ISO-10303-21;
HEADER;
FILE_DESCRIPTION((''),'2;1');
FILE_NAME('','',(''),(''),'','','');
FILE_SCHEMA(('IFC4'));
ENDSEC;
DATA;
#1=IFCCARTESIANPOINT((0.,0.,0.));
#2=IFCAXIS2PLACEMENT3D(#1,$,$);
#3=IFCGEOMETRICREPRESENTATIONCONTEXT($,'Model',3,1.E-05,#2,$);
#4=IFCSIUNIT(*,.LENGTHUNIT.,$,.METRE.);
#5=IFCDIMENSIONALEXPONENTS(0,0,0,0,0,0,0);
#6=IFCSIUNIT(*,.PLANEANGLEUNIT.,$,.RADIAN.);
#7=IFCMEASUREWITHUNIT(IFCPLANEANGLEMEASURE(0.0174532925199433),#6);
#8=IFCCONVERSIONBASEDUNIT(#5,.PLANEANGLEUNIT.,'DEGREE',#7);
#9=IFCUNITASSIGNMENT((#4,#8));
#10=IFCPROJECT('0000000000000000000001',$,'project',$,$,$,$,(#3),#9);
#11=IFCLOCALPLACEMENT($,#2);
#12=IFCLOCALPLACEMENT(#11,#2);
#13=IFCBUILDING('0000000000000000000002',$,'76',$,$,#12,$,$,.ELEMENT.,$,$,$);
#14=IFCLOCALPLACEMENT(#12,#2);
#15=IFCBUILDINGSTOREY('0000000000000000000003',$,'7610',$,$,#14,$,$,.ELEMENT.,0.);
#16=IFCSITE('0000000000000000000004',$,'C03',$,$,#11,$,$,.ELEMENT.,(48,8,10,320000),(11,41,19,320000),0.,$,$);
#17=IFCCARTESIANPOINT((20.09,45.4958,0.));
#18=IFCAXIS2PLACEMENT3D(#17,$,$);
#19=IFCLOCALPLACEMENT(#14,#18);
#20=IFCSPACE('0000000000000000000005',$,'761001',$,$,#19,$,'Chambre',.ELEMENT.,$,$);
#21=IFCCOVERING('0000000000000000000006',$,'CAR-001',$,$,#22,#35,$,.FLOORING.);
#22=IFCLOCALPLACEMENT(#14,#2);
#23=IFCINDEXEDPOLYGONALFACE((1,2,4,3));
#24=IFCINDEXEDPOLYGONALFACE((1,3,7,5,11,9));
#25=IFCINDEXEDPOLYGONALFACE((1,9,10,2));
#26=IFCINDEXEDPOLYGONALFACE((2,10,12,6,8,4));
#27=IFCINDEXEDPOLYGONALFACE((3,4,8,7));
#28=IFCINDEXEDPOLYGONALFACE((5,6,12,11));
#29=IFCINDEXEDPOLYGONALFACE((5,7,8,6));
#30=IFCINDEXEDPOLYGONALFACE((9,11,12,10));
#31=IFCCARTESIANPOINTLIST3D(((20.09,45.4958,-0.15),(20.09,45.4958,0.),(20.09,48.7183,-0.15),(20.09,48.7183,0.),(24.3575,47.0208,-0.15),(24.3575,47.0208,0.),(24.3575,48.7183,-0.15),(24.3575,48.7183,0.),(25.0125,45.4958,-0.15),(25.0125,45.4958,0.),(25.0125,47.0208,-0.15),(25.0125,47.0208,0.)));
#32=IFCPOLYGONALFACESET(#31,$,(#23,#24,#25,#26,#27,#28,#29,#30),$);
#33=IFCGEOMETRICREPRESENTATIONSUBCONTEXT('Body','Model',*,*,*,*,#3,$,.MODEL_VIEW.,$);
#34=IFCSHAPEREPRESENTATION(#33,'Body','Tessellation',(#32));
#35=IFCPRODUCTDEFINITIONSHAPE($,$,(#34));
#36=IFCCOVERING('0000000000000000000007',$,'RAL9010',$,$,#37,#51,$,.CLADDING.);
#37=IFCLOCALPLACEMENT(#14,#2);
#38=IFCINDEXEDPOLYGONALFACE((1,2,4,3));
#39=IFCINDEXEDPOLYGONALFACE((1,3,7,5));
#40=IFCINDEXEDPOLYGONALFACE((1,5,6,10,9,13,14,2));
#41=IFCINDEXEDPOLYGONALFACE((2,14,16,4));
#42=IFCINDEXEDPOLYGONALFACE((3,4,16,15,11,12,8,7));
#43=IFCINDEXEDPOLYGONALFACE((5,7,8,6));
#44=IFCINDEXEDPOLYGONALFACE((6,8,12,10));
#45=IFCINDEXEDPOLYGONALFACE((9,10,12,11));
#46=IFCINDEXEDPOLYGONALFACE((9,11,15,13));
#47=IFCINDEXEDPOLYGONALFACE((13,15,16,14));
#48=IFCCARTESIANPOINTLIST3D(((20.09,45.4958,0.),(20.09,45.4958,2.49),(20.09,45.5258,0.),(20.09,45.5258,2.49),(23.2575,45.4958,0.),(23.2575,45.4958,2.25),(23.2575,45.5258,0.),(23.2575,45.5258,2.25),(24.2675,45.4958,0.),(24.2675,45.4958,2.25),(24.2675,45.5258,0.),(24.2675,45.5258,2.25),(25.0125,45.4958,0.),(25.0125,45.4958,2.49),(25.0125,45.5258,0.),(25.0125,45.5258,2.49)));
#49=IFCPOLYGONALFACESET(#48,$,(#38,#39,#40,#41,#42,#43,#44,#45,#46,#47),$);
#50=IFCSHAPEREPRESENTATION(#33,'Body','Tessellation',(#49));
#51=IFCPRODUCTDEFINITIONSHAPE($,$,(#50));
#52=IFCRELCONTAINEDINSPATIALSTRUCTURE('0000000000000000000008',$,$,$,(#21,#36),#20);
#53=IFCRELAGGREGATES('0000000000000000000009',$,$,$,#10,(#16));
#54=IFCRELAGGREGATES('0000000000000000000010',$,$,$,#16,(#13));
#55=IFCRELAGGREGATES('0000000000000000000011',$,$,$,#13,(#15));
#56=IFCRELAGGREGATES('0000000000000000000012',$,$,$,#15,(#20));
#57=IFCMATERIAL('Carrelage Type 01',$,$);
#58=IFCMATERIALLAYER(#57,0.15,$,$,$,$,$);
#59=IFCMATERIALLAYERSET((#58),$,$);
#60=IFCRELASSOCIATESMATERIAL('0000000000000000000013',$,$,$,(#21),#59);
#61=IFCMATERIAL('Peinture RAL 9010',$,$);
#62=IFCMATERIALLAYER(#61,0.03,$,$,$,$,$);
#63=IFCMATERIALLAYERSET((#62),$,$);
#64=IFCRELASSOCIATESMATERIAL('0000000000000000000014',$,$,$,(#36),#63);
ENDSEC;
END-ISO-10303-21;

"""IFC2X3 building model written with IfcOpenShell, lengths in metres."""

from ifc_helpers import new_model, entity, si_unit, converted_unit, frame, origin, origin_with_axes, place, context, subcontext, project, spatial, polyline, outline, extrude, material, layer, layer_set, layer_usage, element, save


model = new_model("IFC2X3")

# Units and contexts
model_context = context("Model", 3, precision=1e-05, world=origin())
body_context = subcontext(model_context, "Body", "Model", "MODEL_VIEW")
ifc_project = project(units=[si_unit("LENGTHUNIT", "METRE"), converted_unit("PLANEANGLEUNIT", "DEGREE", entity("IfcPlaneAngleMeasure", 0.0174532925199433), si_unit("PLANEANGLEUNIT", "RADIAN"), dimensions=[0, 0, 0, 0, 0, 0, 0])], contexts=[model_context])

# Site, building, storey
site_placement = place(None, origin())
site = spatial("IfcSite", under=ifc_project, at=site_placement, Name="C03", CompositionType="ELEMENT", RefLatitude=(48, 8, 10, 320000), RefLongitude=(11, 41, 19, 320000), RefElevation=0.0)
building_placement = place(site_placement, origin())
building = spatial("IfcBuilding", under=site, at=building_placement, Name="76", CompositionType="ELEMENT")
storey_placement = place(building_placement, origin())
storey = spatial("IfcBuildingStorey", under=building, at=storey_placement, Name="7610", CompositionType="ELEMENT", Elevation=0.0)

# Shared definitions
space_placement = place(storey_placement, frame((20.09, 45.4958, 0.0)))
space = spatial("IfcSpace", under=storey, at=space_placement, Name="761001", LongName="Chambre", CompositionType="ELEMENT")

# Coverings
ifc_material_1 = material(Name="Carrelage Type 01")
ifc_layer_1 = layer(ifc_material_1, 0.15)
ifc_layer_set_1 = layer_set([ifc_layer_1])
ifc_layer_usage_1 = layer_usage(ifc_layer_set_1, "AXIS3", "POSITIVE", 0.0)
covering_1_placement = place(storey_placement, frame((20.09, 45.4958, -0.15)))
element("IfcCovering", 1, at=covering_1_placement, inside=space, material=ifc_layer_usage_1, Name="CAR-001", PredefinedType="FLOORING", context=body_context, shape_type="SweptSolid", body=[
    extrude(outline(polyline([(0.0, 3.2225), (0.0, 0.0), (4.9225, 0.0), (4.9225, 1.525), (4.2675, 1.525), (4.2675, 3.2225), (0.0, 3.2225)])), origin_with_axes(), (0.0, 0.0, 1.0), 0.15),
])
ifc_material_2 = material(Name="Peinture RAL 9010")
ifc_layer_2 = layer(ifc_material_2, 0.03)
ifc_layer_set_2 = layer_set([ifc_layer_2])
ifc_layer_usage_2 = layer_usage(ifc_layer_set_2, "AXIS3", "POSITIVE", 0.0)
covering_2_placement = place(storey_placement, frame((20.09, 45.4958, 0.0)))
element("IfcCovering", 2, at=covering_2_placement, inside=space, material=ifc_layer_usage_2, Name="RAL9010", PredefinedType="CLADDING", context=body_context, shape_type="SweptSolid", body=[
    extrude(outline(polyline([(0.0, 2.49), (3.1675, 2.49), (3.1675, 0.24), (4.1775, 0.24), (4.1775, 2.49), (4.9225, 2.49), (4.9225, 0.0), (0.0, 0.0), (0.0, 2.49)])), frame((0.0, 0.0, 2.49), z_axis=(0.0, 1.0, 0.0), x_axis=(1.0, 0.0, 0.0)), (0.0, 0.0, 1.0), 0.03),
])

save(model, "model.ifc")
